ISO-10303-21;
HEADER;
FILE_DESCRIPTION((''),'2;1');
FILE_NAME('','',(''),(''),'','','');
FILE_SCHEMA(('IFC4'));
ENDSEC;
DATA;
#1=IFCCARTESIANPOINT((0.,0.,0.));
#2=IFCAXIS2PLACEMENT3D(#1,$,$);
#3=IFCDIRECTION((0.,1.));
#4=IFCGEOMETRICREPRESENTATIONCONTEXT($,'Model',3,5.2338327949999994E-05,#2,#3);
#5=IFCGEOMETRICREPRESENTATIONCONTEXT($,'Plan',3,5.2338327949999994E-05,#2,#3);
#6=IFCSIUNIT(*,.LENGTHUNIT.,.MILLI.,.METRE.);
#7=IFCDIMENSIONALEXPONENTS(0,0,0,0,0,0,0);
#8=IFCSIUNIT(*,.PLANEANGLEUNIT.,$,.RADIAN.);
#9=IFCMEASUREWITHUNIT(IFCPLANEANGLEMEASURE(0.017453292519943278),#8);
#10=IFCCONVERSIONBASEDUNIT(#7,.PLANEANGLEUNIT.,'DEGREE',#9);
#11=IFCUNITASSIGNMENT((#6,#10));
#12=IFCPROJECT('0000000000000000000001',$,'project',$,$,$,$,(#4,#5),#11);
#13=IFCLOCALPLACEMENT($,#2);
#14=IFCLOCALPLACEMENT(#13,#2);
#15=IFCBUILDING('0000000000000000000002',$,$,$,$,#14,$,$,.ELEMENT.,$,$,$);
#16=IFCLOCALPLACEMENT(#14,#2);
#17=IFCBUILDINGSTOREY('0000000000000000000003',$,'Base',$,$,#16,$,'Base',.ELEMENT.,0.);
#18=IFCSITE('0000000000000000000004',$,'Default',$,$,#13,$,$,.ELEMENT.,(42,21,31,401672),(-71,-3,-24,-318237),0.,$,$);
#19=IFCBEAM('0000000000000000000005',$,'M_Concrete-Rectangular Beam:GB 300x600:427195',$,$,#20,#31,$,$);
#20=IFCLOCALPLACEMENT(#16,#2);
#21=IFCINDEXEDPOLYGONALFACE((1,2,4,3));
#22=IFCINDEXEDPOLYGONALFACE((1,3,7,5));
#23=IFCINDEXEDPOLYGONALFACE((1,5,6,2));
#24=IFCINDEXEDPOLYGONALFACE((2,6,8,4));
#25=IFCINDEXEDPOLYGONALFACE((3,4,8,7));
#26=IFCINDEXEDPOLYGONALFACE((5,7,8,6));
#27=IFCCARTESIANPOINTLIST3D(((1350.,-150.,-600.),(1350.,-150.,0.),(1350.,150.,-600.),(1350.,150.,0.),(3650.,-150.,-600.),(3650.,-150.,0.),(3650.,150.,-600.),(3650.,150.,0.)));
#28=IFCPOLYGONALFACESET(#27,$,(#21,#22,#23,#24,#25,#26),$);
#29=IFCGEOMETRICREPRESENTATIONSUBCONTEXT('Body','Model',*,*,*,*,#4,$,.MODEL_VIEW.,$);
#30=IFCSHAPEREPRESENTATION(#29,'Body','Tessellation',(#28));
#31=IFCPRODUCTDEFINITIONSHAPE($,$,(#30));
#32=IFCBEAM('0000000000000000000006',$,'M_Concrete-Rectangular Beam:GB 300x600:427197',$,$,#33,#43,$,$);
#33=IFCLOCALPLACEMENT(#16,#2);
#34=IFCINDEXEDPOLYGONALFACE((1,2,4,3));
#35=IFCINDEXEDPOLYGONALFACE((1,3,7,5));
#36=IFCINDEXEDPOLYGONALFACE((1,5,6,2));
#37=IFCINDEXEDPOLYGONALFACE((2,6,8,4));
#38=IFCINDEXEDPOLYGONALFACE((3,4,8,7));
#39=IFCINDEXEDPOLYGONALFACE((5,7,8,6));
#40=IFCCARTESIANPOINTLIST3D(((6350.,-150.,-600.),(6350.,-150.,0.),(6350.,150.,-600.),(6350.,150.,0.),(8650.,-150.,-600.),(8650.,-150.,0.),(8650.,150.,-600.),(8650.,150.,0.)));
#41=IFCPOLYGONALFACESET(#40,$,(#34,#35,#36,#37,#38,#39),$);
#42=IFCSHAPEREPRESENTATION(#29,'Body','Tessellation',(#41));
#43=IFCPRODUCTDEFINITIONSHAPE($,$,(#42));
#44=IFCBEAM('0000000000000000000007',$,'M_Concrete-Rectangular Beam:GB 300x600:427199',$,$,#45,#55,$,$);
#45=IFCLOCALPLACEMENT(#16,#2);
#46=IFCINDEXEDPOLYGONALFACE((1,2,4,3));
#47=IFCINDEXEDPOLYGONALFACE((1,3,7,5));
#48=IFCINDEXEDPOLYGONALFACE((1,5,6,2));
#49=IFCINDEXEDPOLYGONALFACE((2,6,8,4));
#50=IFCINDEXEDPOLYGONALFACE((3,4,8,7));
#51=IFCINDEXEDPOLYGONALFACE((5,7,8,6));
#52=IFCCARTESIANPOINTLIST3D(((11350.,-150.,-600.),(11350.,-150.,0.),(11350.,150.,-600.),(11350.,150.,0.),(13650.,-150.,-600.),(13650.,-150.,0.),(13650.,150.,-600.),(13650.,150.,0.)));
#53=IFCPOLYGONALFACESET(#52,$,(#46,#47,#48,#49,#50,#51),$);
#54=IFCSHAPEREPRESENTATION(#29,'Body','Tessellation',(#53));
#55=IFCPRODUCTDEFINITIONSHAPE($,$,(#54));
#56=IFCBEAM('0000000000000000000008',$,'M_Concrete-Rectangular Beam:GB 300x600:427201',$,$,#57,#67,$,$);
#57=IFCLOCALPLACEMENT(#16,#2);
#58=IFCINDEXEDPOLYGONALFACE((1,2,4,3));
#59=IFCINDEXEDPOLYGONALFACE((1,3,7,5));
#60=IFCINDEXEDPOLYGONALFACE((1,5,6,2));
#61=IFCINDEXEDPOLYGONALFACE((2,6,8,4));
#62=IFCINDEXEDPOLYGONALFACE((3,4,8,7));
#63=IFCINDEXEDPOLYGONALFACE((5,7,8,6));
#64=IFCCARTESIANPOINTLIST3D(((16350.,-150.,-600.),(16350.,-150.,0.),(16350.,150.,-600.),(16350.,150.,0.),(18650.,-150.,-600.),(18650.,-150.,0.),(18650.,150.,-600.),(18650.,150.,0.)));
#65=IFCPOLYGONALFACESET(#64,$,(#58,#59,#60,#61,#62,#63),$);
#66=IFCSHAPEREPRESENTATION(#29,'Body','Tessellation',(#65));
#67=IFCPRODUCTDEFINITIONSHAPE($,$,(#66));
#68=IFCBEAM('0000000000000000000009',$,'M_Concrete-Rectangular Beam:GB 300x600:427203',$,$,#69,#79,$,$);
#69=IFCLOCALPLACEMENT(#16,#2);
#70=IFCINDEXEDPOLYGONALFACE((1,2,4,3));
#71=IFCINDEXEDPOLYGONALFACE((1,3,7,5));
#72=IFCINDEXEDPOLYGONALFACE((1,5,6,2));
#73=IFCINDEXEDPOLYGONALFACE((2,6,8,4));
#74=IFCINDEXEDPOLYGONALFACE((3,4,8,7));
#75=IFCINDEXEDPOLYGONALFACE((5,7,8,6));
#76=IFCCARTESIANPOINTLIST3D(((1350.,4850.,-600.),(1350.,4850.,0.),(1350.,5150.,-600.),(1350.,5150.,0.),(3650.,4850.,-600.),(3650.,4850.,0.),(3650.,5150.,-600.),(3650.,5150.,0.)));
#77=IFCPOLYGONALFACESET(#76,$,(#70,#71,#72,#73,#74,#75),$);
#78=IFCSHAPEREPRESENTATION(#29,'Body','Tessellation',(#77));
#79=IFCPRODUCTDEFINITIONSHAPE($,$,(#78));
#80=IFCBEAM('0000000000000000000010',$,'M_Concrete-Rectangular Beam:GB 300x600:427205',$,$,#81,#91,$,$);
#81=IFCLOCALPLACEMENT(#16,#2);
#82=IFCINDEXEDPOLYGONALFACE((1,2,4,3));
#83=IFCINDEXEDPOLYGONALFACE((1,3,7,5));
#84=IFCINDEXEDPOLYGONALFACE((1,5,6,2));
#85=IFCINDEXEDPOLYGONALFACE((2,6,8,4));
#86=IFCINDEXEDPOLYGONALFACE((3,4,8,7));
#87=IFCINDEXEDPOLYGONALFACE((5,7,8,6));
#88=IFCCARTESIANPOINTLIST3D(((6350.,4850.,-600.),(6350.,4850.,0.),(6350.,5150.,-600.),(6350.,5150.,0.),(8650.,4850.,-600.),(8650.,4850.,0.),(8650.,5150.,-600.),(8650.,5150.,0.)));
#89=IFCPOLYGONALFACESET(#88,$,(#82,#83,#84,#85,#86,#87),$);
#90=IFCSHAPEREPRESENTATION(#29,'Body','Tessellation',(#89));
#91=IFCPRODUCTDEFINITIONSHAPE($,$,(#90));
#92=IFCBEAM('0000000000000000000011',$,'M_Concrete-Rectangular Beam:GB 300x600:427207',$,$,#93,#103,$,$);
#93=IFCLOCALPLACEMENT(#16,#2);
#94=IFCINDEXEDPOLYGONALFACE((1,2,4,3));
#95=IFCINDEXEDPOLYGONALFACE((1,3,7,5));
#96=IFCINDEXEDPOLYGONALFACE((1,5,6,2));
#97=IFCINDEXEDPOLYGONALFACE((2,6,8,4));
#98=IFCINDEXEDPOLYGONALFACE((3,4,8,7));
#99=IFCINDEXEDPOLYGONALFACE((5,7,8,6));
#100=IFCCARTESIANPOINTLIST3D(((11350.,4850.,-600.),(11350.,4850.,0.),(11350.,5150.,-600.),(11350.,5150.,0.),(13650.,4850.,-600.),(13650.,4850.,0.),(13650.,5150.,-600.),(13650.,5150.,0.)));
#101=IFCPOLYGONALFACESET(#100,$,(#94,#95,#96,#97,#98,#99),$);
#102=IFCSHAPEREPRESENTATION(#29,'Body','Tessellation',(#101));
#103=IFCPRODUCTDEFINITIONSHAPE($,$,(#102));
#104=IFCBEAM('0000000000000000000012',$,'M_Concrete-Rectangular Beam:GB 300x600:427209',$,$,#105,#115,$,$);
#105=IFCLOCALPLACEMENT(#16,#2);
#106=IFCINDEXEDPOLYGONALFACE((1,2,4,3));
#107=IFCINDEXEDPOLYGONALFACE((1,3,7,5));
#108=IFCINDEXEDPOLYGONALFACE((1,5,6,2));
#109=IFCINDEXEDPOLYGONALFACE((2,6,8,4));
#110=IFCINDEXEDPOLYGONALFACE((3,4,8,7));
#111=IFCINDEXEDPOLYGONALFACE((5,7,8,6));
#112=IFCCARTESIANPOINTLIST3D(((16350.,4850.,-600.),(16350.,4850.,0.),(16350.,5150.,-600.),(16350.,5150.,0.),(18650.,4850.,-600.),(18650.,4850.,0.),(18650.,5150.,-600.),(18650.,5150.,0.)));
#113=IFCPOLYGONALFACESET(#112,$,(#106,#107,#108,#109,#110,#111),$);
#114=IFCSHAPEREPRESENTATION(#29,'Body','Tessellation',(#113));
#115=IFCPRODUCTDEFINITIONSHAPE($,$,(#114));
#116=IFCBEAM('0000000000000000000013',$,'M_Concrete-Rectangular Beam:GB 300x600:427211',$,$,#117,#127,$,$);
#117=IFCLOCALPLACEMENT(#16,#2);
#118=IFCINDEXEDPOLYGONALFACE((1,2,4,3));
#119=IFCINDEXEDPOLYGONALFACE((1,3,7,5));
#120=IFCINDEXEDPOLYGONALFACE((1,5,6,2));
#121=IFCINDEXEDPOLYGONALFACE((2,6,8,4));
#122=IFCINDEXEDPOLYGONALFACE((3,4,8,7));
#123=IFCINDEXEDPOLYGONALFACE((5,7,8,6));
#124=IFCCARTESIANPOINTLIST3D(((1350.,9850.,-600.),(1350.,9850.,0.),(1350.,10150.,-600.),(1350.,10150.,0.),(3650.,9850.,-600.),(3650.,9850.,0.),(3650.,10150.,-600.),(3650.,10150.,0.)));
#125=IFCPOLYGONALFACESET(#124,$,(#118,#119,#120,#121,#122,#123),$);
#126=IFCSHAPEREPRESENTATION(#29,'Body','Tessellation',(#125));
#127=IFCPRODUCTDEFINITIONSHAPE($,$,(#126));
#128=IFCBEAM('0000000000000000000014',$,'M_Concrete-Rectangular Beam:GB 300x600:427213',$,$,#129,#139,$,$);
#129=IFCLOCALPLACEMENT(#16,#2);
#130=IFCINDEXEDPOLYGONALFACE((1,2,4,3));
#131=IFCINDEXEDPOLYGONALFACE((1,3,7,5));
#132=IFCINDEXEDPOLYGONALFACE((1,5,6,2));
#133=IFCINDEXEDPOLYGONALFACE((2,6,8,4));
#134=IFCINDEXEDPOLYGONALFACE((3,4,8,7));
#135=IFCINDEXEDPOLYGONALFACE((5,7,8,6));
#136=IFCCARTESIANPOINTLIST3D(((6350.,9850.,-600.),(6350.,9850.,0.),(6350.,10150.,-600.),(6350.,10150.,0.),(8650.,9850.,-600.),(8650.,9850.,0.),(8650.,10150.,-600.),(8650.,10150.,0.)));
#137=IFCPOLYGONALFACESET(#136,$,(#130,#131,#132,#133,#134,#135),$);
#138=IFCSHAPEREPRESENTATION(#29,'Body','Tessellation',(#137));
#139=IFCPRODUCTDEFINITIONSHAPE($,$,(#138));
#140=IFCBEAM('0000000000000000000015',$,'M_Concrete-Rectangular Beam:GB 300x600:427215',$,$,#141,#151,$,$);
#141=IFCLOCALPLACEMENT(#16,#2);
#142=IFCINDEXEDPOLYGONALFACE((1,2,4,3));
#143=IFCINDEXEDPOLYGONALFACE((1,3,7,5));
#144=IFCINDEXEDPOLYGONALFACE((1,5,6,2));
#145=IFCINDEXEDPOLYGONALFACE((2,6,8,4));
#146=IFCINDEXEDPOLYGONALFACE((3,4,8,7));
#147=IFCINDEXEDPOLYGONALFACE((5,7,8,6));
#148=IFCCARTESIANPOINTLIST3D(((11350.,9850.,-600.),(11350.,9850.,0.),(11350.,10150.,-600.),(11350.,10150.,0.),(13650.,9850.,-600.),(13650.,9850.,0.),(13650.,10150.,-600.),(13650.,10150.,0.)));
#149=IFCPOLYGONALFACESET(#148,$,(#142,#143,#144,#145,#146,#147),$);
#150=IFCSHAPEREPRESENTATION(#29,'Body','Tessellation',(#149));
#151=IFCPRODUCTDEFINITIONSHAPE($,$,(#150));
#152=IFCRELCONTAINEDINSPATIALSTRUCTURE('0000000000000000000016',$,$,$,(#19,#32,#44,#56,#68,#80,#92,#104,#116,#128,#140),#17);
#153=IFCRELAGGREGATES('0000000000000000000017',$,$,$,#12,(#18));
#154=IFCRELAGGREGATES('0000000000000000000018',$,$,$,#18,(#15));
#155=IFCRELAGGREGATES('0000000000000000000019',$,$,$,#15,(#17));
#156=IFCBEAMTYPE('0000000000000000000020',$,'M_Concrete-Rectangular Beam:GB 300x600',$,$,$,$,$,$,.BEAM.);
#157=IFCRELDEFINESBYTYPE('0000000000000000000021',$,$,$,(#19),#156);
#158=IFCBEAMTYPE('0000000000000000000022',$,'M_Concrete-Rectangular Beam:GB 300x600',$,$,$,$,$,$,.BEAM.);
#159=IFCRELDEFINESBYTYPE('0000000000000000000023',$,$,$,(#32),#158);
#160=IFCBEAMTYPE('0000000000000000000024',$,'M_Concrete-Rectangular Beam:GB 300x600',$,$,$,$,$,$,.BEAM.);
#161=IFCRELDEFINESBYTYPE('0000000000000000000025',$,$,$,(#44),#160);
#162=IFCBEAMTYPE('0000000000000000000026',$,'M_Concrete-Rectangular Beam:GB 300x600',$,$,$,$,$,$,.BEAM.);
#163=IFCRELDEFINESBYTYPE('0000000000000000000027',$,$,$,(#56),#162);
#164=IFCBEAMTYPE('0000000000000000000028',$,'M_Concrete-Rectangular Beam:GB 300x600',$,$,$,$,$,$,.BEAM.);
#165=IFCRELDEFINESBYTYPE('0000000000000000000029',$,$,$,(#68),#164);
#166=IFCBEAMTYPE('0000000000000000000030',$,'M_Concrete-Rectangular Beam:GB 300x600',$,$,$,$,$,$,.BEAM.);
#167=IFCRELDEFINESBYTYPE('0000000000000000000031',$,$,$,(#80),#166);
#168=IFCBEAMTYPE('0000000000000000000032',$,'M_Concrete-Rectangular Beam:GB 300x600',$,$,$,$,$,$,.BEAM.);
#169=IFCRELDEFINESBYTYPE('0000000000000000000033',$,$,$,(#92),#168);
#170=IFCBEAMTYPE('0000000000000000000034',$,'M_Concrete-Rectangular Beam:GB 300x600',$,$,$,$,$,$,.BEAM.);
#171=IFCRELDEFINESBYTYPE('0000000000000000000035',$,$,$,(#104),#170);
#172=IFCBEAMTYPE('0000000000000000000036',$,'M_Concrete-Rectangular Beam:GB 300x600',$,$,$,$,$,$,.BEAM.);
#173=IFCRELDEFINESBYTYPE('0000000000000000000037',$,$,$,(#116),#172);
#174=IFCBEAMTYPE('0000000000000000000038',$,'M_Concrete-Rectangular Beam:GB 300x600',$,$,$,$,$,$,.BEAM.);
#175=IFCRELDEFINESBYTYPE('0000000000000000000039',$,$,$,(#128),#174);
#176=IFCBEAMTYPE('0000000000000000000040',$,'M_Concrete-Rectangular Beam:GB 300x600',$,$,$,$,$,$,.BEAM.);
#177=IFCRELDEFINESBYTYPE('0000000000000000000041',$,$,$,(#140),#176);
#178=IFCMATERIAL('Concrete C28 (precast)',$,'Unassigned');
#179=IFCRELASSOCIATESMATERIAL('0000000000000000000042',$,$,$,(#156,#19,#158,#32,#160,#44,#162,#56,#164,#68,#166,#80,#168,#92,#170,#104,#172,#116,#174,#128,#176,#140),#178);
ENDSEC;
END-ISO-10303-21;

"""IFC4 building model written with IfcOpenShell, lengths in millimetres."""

from ifc_helpers import new_model, entity, si_unit, converted_unit, direction, frame, origin, place, context, subcontext, project, spatial, indexed_curve, outline, extrude, source, transform, mapped, material, type_object, type_shapes, element, save


model = new_model("IFC4")

# Units and contexts
model_context = context("Model", 3, precision=5.2338327949999994e-05, world=origin(), true_north=direction((0.0, 1.0)))
plan_context = context("Plan", 3, precision=5.2338327949999994e-05, world=origin(), true_north=direction((0.0, 1.0)))
body_context = subcontext(model_context, "Body", "Model", "MODEL_VIEW")
ifc_project = project(units=[si_unit("LENGTHUNIT", "METRE", prefix="MILLI"), converted_unit("PLANEANGLEUNIT", "DEGREE", entity("IfcPlaneAngleMeasure", 0.017453292519943278), si_unit("PLANEANGLEUNIT", "RADIAN"), dimensions=[0, 0, 0, 0, 0, 0, 0])], contexts=[model_context, plan_context])

# Site, building, storey
site_placement = place(None, origin())
site = spatial("IfcSite", under=ifc_project, at=site_placement, Name="Default", CompositionType="ELEMENT", RefLatitude=(42, 21, 31, 401672), RefLongitude=(-71, -3, -24, -318237), RefElevation=0.0)
building_placement = place(site_placement, origin())
building = spatial("IfcBuilding", under=site, at=building_placement, CompositionType="ELEMENT")
storey_placement = place(building_placement, origin())
storey = spatial("IfcBuildingStorey", under=building, at=storey_placement, Name="Base", LongName="Base", CompositionType="ELEMENT", Elevation=0.0)

# Beams
ifc_material = material(Name="Concrete C28 (precast)", Category="Unassigned")
beam_type_1 = type_object("IfcBeamType", Name="M_Concrete-Rectangular Beam:GB 300x600", PredefinedType="BEAM", material=ifc_material)
shared_shape_1 = source(origin(), body_context, "Body", "SweptSolid", [
    extrude(outline(indexed_curve([(-300.0, -150.0), (300.0, -150.0), (300.0, 150.0), (-300.0, 150.0), (-300.0, -150.0)], self_intersect=False)), frame((1350.0, 0.0, -300.0), z_axis=(1.0, 0.0, 0.0), x_axis=(0.0, 0.0, -1.0)), (0.0, 0.0, 1.0), 2300.0),
])
type_shapes(beam_type_1, [shared_shape_1])
beam_1_placement = place(storey_placement, origin())
element("IfcBeam", 1, at=beam_1_placement, inside=storey, type_object=beam_type_1, material=ifc_material, Name="M_Concrete-Rectangular Beam:GB 300x600:427195", context=body_context, shape_type="MappedRepresentation", body=[
    mapped(shared_shape_1, transform((0.0, 0.0, 0.0), scale=1.0)),
])
beam_type_2 = type_object("IfcBeamType", Name="M_Concrete-Rectangular Beam:GB 300x600", PredefinedType="BEAM", material=ifc_material)
shared_shape_2 = source(origin(), body_context, "Body", "SweptSolid", [
    extrude(outline(indexed_curve([(-300.0, -150.0), (300.0, -150.0), (300.0, 150.0), (-300.0, 150.0), (-300.0, -150.0)], self_intersect=False)), frame((6350.0, 0.0, -300.0), z_axis=(1.0, 0.0, 0.0), x_axis=(0.0, 0.0, -1.0)), (0.0, 0.0, 1.0), 2300.0),
])
type_shapes(beam_type_2, [shared_shape_2])
beam_2_placement = place(storey_placement, origin())
element("IfcBeam", 2, at=beam_2_placement, inside=storey, type_object=beam_type_2, material=ifc_material, Name="M_Concrete-Rectangular Beam:GB 300x600:427197", context=body_context, shape_type="MappedRepresentation", body=[
    mapped(shared_shape_2, transform((0.0, 0.0, 0.0), scale=1.0)),
])
beam_type_3 = type_object("IfcBeamType", Name="M_Concrete-Rectangular Beam:GB 300x600", PredefinedType="BEAM", material=ifc_material)
shared_shape_3 = source(origin(), body_context, "Body", "SweptSolid", [
    extrude(outline(indexed_curve([(-300.0, -150.0), (300.0, -150.0), (300.0, 150.0), (-300.0, 150.0), (-300.0, -150.0)], self_intersect=False)), frame((11350.0, 0.0, -300.0), z_axis=(1.0, 0.0, 0.0), x_axis=(0.0, 0.0, -1.0)), (0.0, 0.0, 1.0), 2300.0),
])
type_shapes(beam_type_3, [shared_shape_3])
beam_3_placement = place(storey_placement, origin())
element("IfcBeam", 3, at=beam_3_placement, inside=storey, type_object=beam_type_3, material=ifc_material, Name="M_Concrete-Rectangular Beam:GB 300x600:427199", context=body_context, shape_type="MappedRepresentation", body=[
    mapped(shared_shape_3, transform((0.0, 0.0, 0.0), scale=1.0)),
])
beam_type_4 = type_object("IfcBeamType", Name="M_Concrete-Rectangular Beam:GB 300x600", PredefinedType="BEAM", material=ifc_material)
shared_shape_4 = source(origin(), body_context, "Body", "SweptSolid", [
    extrude(outline(indexed_curve([(-300.0, -150.0), (300.0, -150.0), (300.0, 150.0), (-300.0, 150.0), (-300.0, -150.0)], self_intersect=False)), frame((16350.0, 0.0, -300.0), z_axis=(1.0, 0.0, 0.0), x_axis=(0.0, 0.0, -1.0)), (0.0, 0.0, 1.0), 2300.0),
])
type_shapes(beam_type_4, [shared_shape_4])
beam_4_placement = place(storey_placement, origin())
element("IfcBeam", 4, at=beam_4_placement, inside=storey, type_object=beam_type_4, material=ifc_material, Name="M_Concrete-Rectangular Beam:GB 300x600:427201", context=body_context, shape_type="MappedRepresentation", body=[
    mapped(shared_shape_4, transform((0.0, 0.0, 0.0), scale=1.0)),
])
beam_type_5 = type_object("IfcBeamType", Name="M_Concrete-Rectangular Beam:GB 300x600", PredefinedType="BEAM", material=ifc_material)
shared_shape_5 = source(origin(), body_context, "Body", "SweptSolid", [
    extrude(outline(indexed_curve([(-300.0, -150.0), (300.0, -150.0), (300.0, 150.0), (-300.0, 150.0), (-300.0, -150.0)], self_intersect=False)), frame((1350.0, 5000.0, -300.0), z_axis=(1.0, 0.0, 0.0), x_axis=(0.0, 0.0, -1.0)), (0.0, 0.0, 1.0), 2300.0),
])
type_shapes(beam_type_5, [shared_shape_5])
beam_5_placement = place(storey_placement, origin())
element("IfcBeam", 5, at=beam_5_placement, inside=storey, type_object=beam_type_5, material=ifc_material, Name="M_Concrete-Rectangular Beam:GB 300x600:427203", context=body_context, shape_type="MappedRepresentation", body=[
    mapped(shared_shape_5, transform((0.0, 0.0, 0.0), scale=1.0)),
])
beam_type_6 = type_object("IfcBeamType", Name="M_Concrete-Rectangular Beam:GB 300x600", PredefinedType="BEAM", material=ifc_material)
shared_shape_6 = source(origin(), body_context, "Body", "SweptSolid", [
    extrude(outline(indexed_curve([(-300.0, -150.0), (300.0, -150.0), (300.0, 150.0), (-300.0, 150.0), (-300.0, -150.0)], self_intersect=False)), frame((6350.0, 5000.0, -300.0), z_axis=(1.0, 0.0, 0.0), x_axis=(0.0, 0.0, -1.0)), (0.0, 0.0, 1.0), 2300.0),
])
type_shapes(beam_type_6, [shared_shape_6])
beam_6_placement = place(storey_placement, origin())
element("IfcBeam", 6, at=beam_6_placement, inside=storey, type_object=beam_type_6, material=ifc_material, Name="M_Concrete-Rectangular Beam:GB 300x600:427205", context=body_context, shape_type="MappedRepresentation", body=[
    mapped(shared_shape_6, transform((0.0, 0.0, 0.0), scale=1.0)),
])
beam_type_7 = type_object("IfcBeamType", Name="M_Concrete-Rectangular Beam:GB 300x600", PredefinedType="BEAM", material=ifc_material)
shared_shape_7 = source(origin(), body_context, "Body", "SweptSolid", [
    extrude(outline(indexed_curve([(-300.0, -150.0), (300.0, -150.0), (300.0, 150.0), (-300.0, 150.0), (-300.0, -150.0)], self_intersect=False)), frame((11350.0, 5000.0, -300.0), z_axis=(1.0, 0.0, 0.0), x_axis=(0.0, 0.0, -1.0)), (0.0, 0.0, 1.0), 2300.0),
])
type_shapes(beam_type_7, [shared_shape_7])
beam_7_placement = place(storey_placement, origin())
element("IfcBeam", 7, at=beam_7_placement, inside=storey, type_object=beam_type_7, material=ifc_material, Name="M_Concrete-Rectangular Beam:GB 300x600:427207", context=body_context, shape_type="MappedRepresentation", body=[
    mapped(shared_shape_7, transform((0.0, 0.0, 0.0), scale=1.0)),
])
beam_type_8 = type_object("IfcBeamType", Name="M_Concrete-Rectangular Beam:GB 300x600", PredefinedType="BEAM", material=ifc_material)
shared_shape_8 = source(origin(), body_context, "Body", "SweptSolid", [
    extrude(outline(indexed_curve([(-300.0, -150.0), (300.0, -150.0), (300.0, 150.0), (-300.0, 150.0), (-300.0, -150.0)], self_intersect=False)), frame((16350.0, 5000.0, -300.0), z_axis=(1.0, 0.0, 0.0), x_axis=(0.0, 0.0, -1.0)), (0.0, 0.0, 1.0), 2300.0),
])
type_shapes(beam_type_8, [shared_shape_8])
beam_8_placement = place(storey_placement, origin())
element("IfcBeam", 8, at=beam_8_placement, inside=storey, type_object=beam_type_8, material=ifc_material, Name="M_Concrete-Rectangular Beam:GB 300x600:427209", context=body_context, shape_type="MappedRepresentation", body=[
    mapped(shared_shape_8, transform((0.0, 0.0, 0.0), scale=1.0)),
])
beam_type_9 = type_object("IfcBeamType", Name="M_Concrete-Rectangular Beam:GB 300x600", PredefinedType="BEAM", material=ifc_material)
shared_shape_9 = source(origin(), body_context, "Body", "SweptSolid", [
    extrude(outline(indexed_curve([(-300.0, -150.0), (300.0, -150.0), (300.0, 150.0), (-300.0, 150.0), (-300.0, -150.0)], self_intersect=False)), frame((1350.0, 10000.0, -300.0), z_axis=(1.0, 0.0, 0.0), x_axis=(0.0, 0.0, -1.0)), (0.0, 0.0, 1.0), 2300.0),
])
type_shapes(beam_type_9, [shared_shape_9])
beam_9_placement = place(storey_placement, origin())
element("IfcBeam", 9, at=beam_9_placement, inside=storey, type_object=beam_type_9, material=ifc_material, Name="M_Concrete-Rectangular Beam:GB 300x600:427211", context=body_context, shape_type="MappedRepresentation", body=[
    mapped(shared_shape_9, transform((0.0, 0.0, 0.0), scale=1.0)),
])
beam_type_10 = type_object("IfcBeamType", Name="M_Concrete-Rectangular Beam:GB 300x600", PredefinedType="BEAM", material=ifc_material)
shared_shape_10 = source(origin(), body_context, "Body", "SweptSolid", [
    extrude(outline(indexed_curve([(-300.0, -150.0), (300.0, -150.0), (300.0, 150.0), (-300.0, 150.0), (-300.0, -150.0)], self_intersect=False)), frame((6350.0, 10000.0, -300.0), z_axis=(1.0, 0.0, 0.0), x_axis=(0.0, 0.0, -1.0)), (0.0, 0.0, 1.0), 2300.0),
])
type_shapes(beam_type_10, [shared_shape_10])
beam_10_placement = place(storey_placement, origin())
element("IfcBeam", 10, at=beam_10_placement, inside=storey, type_object=beam_type_10, material=ifc_material, Name="M_Concrete-Rectangular Beam:GB 300x600:427213", context=body_context, shape_type="MappedRepresentation", body=[
    mapped(shared_shape_10, transform((0.0, 0.0, 0.0), scale=1.0)),
])
beam_type_11 = type_object("IfcBeamType", Name="M_Concrete-Rectangular Beam:GB 300x600", PredefinedType="BEAM", material=ifc_material)
shared_shape_11 = source(origin(), body_context, "Body", "SweptSolid", [
    extrude(outline(indexed_curve([(-300.0, -150.0), (300.0, -150.0), (300.0, 150.0), (-300.0, 150.0), (-300.0, -150.0)], self_intersect=False)), frame((11350.0, 10000.0, -300.0), z_axis=(1.0, 0.0, 0.0), x_axis=(0.0, 0.0, -1.0)), (0.0, 0.0, 1.0), 2300.0),
])
type_shapes(beam_type_11, [shared_shape_11])
beam_11_placement = place(storey_placement, origin())
element("IfcBeam", 11, at=beam_11_placement, inside=storey, type_object=beam_type_11, material=ifc_material, Name="M_Concrete-Rectangular Beam:GB 300x600:427215", context=body_context, shape_type="MappedRepresentation", body=[
    mapped(shared_shape_11, transform((0.0, 0.0, 0.0), scale=1.0)),
])

save(model, "model.ifc")
